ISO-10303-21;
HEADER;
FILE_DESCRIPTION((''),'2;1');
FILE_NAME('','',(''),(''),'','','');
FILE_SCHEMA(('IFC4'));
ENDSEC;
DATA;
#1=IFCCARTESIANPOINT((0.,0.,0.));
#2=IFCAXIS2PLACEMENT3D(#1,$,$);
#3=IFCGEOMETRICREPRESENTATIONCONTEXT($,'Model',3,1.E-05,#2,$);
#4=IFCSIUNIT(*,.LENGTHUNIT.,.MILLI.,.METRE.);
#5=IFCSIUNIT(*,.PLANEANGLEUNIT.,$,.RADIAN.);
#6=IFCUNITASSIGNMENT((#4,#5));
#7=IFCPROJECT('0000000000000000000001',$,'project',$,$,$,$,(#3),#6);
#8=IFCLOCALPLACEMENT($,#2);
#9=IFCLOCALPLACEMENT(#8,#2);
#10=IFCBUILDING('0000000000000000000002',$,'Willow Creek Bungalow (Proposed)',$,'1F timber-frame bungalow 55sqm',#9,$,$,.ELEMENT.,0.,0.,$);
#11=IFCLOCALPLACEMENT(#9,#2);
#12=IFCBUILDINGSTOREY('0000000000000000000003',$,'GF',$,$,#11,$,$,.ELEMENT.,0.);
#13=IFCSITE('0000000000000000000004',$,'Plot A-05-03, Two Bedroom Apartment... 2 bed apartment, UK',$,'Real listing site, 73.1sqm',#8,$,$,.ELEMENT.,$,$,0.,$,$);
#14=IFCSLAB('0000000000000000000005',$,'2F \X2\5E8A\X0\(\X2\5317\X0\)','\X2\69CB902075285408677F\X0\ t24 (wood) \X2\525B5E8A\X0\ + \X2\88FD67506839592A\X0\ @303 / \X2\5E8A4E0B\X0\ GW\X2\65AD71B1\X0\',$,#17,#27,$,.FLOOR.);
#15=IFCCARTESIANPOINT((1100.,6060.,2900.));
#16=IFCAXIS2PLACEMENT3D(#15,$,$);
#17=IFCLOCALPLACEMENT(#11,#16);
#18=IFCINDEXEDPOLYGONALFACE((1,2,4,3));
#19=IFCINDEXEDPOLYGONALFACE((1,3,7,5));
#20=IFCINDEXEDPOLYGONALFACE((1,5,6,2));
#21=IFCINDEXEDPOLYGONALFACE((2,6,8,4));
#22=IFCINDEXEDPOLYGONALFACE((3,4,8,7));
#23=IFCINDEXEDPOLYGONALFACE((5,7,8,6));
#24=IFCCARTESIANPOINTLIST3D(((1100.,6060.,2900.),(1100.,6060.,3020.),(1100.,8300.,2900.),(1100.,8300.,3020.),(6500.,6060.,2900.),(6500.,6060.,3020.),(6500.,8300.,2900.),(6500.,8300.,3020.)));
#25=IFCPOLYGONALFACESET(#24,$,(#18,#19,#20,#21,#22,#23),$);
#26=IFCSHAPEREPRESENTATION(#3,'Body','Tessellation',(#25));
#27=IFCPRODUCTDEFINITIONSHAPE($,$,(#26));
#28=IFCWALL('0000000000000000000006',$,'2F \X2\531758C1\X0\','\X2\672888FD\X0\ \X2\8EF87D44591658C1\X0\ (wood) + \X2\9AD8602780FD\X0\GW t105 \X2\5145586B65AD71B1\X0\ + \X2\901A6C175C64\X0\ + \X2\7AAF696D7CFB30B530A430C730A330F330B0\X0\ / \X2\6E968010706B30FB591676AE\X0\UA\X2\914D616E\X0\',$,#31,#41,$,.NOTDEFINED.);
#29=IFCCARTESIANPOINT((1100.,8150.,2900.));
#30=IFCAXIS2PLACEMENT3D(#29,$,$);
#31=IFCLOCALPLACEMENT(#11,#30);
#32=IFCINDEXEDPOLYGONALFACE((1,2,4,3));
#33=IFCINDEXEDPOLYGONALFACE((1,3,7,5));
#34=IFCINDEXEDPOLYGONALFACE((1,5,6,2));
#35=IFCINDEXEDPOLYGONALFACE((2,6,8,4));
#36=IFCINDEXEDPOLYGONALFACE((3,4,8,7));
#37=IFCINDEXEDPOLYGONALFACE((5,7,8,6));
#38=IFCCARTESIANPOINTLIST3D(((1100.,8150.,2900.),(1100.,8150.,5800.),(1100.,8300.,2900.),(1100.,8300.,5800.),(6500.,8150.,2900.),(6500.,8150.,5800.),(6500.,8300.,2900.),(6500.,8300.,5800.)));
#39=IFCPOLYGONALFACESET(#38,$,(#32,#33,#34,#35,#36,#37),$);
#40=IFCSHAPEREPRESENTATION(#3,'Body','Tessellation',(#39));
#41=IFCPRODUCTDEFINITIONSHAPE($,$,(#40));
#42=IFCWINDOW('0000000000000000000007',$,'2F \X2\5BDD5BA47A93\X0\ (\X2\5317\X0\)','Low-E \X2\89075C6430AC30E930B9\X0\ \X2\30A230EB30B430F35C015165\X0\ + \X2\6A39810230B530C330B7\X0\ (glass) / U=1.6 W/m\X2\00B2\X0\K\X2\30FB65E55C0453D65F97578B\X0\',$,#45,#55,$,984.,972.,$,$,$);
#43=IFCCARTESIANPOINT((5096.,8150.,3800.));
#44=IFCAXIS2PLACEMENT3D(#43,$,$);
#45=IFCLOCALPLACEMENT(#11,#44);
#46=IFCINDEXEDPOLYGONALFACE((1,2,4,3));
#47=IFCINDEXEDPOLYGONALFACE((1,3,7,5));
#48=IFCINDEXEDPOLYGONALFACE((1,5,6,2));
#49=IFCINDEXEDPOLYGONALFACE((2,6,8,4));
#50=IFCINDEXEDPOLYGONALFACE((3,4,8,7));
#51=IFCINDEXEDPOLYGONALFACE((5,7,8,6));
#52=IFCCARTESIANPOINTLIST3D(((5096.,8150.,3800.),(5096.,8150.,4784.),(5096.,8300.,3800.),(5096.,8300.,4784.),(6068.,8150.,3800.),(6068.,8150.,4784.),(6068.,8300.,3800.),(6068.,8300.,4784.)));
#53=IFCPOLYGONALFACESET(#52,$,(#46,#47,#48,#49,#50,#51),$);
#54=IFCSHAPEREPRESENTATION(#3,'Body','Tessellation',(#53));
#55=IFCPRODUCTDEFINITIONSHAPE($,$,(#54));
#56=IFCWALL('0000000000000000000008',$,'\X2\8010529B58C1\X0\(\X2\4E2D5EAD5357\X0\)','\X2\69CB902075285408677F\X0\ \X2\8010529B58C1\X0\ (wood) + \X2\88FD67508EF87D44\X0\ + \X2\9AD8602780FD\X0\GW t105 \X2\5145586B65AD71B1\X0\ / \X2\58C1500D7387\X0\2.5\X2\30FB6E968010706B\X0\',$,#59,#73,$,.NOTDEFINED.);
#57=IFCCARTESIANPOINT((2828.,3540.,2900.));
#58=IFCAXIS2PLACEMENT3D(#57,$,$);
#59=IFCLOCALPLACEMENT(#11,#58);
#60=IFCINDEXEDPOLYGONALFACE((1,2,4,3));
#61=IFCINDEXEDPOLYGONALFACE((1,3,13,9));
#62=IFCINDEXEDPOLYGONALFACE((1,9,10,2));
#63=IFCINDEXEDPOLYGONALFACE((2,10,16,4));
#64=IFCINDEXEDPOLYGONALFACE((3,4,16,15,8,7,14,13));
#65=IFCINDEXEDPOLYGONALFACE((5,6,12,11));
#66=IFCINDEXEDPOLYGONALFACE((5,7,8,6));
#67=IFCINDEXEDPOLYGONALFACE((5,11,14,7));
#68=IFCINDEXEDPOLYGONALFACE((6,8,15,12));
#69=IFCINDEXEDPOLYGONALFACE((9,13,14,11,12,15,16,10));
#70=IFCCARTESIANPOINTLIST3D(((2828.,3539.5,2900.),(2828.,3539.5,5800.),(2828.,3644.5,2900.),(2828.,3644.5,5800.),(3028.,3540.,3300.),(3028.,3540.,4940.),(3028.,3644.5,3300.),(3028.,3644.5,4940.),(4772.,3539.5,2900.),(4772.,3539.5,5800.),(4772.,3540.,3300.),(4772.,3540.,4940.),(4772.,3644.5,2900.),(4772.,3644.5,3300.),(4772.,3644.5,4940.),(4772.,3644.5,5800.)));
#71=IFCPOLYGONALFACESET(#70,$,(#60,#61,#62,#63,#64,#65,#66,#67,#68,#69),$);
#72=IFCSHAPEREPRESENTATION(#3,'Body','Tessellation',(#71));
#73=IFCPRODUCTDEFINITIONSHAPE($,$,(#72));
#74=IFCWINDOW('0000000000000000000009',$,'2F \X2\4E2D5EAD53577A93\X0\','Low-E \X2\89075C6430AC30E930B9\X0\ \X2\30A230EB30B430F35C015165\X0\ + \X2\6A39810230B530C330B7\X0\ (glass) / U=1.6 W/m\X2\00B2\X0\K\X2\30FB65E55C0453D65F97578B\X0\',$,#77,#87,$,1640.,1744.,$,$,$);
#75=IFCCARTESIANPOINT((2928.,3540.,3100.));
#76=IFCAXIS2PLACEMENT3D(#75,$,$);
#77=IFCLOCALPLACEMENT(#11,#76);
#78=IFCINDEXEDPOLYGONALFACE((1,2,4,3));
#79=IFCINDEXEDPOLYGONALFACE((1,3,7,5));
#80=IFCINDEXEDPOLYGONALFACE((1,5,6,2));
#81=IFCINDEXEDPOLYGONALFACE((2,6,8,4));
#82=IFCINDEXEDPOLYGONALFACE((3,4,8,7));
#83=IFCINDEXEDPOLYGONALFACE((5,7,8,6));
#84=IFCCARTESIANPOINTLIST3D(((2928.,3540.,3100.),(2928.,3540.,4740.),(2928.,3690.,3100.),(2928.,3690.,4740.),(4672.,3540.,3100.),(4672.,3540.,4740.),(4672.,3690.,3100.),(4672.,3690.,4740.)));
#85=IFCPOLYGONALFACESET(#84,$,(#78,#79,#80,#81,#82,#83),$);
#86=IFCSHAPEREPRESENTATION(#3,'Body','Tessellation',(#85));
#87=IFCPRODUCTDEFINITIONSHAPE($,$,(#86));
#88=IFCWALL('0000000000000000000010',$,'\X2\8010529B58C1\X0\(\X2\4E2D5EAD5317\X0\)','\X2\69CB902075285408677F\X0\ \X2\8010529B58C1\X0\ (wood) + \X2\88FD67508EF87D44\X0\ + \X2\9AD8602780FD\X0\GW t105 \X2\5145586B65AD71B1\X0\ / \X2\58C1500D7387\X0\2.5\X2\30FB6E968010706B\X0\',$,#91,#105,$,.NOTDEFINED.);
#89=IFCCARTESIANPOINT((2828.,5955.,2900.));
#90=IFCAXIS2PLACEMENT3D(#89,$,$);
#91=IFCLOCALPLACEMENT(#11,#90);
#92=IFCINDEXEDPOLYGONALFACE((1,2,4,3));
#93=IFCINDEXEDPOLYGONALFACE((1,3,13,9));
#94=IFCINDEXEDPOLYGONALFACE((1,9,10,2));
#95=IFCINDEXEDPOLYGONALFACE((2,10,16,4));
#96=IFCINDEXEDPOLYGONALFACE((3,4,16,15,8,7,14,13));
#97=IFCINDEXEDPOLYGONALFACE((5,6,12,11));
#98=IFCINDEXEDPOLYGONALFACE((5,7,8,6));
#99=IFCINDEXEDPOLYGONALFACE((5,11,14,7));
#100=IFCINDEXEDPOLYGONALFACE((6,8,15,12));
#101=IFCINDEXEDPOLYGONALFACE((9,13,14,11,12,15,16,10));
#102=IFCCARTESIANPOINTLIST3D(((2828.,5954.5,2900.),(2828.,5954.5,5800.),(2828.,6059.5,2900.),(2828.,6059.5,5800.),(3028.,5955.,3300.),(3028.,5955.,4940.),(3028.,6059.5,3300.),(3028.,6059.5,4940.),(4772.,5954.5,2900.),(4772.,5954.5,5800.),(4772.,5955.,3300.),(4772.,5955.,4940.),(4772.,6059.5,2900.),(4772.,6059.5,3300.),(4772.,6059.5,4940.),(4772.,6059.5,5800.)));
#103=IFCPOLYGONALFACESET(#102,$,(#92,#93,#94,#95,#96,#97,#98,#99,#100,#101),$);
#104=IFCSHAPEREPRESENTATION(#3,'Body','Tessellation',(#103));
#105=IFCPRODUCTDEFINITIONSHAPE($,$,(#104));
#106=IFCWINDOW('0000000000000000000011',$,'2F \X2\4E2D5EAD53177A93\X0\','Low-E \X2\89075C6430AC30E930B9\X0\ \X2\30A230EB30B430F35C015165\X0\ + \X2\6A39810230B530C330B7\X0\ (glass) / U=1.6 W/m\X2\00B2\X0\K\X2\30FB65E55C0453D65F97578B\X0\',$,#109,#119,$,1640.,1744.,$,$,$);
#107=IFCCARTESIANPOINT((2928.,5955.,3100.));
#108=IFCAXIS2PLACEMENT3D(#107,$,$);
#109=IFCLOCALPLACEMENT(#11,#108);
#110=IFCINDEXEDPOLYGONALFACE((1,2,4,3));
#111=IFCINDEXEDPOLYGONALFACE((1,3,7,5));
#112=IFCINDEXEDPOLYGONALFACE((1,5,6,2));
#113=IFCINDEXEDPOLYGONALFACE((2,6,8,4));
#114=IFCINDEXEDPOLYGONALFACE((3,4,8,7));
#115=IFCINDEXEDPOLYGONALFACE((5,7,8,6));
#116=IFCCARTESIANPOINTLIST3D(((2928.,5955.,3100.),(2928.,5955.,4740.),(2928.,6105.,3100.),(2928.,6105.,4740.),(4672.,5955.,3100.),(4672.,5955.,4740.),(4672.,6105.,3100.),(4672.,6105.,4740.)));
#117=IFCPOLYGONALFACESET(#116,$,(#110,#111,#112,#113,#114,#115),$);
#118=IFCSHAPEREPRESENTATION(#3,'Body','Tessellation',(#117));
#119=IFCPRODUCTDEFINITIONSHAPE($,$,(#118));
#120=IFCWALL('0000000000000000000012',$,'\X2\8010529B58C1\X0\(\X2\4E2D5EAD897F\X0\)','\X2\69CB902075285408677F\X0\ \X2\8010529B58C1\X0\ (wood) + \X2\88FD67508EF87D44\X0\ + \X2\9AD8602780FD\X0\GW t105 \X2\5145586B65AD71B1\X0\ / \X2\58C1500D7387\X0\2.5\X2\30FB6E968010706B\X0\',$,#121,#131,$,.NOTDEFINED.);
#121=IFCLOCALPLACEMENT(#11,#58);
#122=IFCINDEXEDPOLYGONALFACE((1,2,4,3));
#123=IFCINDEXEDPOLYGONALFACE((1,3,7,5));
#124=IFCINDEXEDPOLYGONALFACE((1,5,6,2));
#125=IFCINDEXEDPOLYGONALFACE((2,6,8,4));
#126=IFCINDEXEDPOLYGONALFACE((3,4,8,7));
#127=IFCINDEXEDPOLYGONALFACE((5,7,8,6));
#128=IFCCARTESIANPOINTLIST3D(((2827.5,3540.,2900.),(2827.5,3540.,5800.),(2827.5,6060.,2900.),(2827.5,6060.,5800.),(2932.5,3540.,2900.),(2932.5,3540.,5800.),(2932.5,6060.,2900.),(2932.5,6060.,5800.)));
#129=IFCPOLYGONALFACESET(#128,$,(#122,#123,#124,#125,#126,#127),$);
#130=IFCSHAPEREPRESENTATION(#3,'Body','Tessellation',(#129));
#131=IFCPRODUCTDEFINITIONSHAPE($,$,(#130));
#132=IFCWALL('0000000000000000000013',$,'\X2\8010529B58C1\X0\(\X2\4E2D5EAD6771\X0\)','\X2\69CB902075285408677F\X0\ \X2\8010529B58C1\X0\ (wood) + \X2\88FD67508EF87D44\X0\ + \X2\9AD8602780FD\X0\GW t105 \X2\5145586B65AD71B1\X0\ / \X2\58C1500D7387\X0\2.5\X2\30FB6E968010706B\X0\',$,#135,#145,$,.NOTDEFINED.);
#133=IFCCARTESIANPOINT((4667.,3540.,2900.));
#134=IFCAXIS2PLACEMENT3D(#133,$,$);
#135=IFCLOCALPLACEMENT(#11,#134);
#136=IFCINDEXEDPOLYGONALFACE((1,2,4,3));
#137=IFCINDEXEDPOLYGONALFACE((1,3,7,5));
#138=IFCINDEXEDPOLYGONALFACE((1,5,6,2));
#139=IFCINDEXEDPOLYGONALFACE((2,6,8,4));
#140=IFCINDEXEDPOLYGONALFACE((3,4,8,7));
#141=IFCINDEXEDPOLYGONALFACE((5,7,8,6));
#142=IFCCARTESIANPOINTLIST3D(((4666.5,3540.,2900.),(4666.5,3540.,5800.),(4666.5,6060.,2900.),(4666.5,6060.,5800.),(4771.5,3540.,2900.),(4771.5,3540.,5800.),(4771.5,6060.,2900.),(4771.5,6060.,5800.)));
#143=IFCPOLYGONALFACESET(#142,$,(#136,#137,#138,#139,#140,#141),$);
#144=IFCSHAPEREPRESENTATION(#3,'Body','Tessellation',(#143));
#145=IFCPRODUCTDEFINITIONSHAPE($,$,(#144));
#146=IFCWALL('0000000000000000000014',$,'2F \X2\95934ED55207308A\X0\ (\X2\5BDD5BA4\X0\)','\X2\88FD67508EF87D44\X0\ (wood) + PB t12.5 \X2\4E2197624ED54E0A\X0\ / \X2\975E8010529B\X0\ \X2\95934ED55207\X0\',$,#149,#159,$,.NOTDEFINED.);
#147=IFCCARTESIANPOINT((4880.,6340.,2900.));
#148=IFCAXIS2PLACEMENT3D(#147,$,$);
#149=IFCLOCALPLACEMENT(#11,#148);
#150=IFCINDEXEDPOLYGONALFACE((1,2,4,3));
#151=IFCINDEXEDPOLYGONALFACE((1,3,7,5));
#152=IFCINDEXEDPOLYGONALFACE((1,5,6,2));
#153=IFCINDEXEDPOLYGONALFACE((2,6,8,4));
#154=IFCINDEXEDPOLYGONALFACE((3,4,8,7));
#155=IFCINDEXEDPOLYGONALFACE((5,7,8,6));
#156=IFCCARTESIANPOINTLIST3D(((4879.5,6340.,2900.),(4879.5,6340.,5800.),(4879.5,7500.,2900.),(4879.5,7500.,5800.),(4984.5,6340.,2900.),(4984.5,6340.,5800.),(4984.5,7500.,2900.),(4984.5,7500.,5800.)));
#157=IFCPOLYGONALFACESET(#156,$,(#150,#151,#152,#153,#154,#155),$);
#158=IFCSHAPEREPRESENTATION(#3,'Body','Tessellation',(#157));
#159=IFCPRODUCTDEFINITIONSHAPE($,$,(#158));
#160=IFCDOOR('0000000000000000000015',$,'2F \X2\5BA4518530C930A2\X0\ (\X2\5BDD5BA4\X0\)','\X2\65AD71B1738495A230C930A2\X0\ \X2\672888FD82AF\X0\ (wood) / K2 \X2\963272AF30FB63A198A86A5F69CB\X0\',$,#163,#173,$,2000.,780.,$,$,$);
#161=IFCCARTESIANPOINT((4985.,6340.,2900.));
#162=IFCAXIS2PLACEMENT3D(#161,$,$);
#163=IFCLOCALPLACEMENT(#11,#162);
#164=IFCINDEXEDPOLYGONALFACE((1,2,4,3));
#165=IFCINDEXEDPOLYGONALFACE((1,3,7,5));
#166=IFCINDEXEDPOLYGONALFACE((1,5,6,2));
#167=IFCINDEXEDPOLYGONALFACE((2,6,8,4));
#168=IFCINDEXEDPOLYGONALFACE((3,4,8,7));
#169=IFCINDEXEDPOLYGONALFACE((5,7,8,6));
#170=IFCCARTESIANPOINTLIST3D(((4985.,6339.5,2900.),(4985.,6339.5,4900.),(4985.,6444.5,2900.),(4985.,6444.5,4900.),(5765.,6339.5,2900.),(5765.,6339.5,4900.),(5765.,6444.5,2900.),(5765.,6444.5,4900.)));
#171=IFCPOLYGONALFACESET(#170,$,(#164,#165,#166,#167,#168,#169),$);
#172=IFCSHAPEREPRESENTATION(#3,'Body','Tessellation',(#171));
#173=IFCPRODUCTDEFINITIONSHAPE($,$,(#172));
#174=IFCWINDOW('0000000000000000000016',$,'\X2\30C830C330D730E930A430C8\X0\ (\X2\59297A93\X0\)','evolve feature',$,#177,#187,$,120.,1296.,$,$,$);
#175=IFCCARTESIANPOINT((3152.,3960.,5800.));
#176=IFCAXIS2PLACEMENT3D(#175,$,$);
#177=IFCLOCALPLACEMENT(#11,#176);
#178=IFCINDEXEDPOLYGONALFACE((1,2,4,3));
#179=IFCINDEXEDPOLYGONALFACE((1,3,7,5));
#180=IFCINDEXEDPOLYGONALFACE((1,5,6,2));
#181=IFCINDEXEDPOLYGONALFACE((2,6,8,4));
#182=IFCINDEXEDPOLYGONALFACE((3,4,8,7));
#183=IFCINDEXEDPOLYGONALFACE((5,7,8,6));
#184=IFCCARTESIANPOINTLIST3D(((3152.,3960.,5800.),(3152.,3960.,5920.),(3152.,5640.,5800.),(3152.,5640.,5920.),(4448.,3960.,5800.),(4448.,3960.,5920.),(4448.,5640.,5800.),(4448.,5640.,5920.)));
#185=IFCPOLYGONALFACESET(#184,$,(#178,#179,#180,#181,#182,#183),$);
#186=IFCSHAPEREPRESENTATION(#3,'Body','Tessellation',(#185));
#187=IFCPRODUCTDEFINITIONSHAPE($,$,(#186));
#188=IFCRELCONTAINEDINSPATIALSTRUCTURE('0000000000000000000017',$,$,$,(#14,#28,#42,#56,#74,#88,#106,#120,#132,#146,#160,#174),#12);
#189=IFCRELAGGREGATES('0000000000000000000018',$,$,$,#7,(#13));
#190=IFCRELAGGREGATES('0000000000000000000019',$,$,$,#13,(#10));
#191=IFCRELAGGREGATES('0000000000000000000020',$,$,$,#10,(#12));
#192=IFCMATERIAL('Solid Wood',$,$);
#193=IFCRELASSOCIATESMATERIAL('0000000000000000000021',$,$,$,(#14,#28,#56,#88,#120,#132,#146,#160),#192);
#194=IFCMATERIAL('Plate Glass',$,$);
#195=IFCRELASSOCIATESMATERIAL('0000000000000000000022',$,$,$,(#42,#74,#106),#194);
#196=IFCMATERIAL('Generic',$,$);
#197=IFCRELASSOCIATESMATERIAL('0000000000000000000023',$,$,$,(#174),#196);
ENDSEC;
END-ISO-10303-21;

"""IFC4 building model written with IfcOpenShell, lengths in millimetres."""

from ifc_helpers import new_model, si_unit, frame, frame_2d, origin, place, context, project, spatial, rectangle, extrude, material, element, fill, save


model = new_model("IFC4")

# Units and contexts
model_context = context("Model", 3, precision=1e-05, world=origin())
ifc_project = project(units=[si_unit("LENGTHUNIT", "METRE", prefix="MILLI"), si_unit("PLANEANGLEUNIT", "RADIAN")], contexts=[model_context])

# Site, building, storey
site_placement = place(None, origin())
site = spatial("IfcSite", under=ifc_project, at=site_placement, Name="Plot A-05-03, Two Bedroom Apartment... 2 bed apartment, UK", ObjectType="Real listing site, 73.1sqm", CompositionType="ELEMENT", RefElevation=0.0)
building_placement = place(site_placement, origin())
building = spatial("IfcBuilding", under=site, at=building_placement, Name="Willow Creek Bungalow (Proposed)", ObjectType="1F timber-frame bungalow 55sqm", CompositionType="ELEMENT", ElevationOfRefHeight=0.0, ElevationOfTerrain=0.0)
storey_placement = place(building_placement, origin())
storey = spatial("IfcBuildingStorey", under=building, at=storey_placement, Name="GF", CompositionType="ELEMENT", Elevation=0.0)

# Slab
ifc_material_1 = material(Name="Solid Wood")
slab_placement = place(storey_placement, frame((1100.0, 6060.0, 2900.0)))
element("IfcSlab", 1, at=slab_placement, inside=storey, material=ifc_material_1, Name="2F 床(北)", Description="構造用合板 t24 (wood) 剛床 + 製材根太 @303 / 床下 GW断熱", PredefinedType="FLOOR", context=model_context, shape_type="SweptSolid", body=[
    extrude(rectangle(XDim=5400.0, YDim=2240.0, at=frame_2d((2700.0, 1120.0))), frame((1100.0, 6060.0, 2900.0)), (0.0, 0.0, 1.0), 120.0),
])

# Walls, openings, windows
wall_1_placement = place(storey_placement, frame((1100.0, 8150.0, 2900.0)))
wall_1 = element("IfcWall", 2, at=wall_1_placement, inside=storey, material=ifc_material_1, Name="2F 北壁", Description="木製 軸組外壁 (wood) + 高性能GW t105 充填断熱 + 通気層 + 窯業系サイディング / 準耐火・外皮UA配慮", PredefinedType="NOTDEFINED", context=model_context, shape_type="SweptSolid", body=[
    extrude(rectangle(XDim=5400.0, YDim=150.0, at=frame_2d((2700.0, 75.0))), frame((1100.0, 8150.0, 2900.0)), (0.0, 0.0, 1.0), 2900.0),
])
opening_1_placement = place(storey_placement, frame((5096.0, 8150.0, 3800.0)))
opening_1 = element("IfcOpeningElement", 3, at=opening_1_placement, cuts=wall_1, PredefinedType="NOTDEFINED", context=model_context, shape_type="SweptSolid", body=[
    extrude(rectangle(XDim=972.0, YDim=150.0, at=frame_2d((486.0, 75.0))), frame((5096.0, 8150.0, 3800.0)), (0.0, 0.0, 1.0), 984.0),
])
ifc_material_2 = material(Name="Plate Glass")
window_1_placement = place(storey_placement, frame((5096.0, 8150.0, 3800.0)))
window_1 = element("IfcWindow", 4, at=window_1_placement, inside=storey, material=ifc_material_2, Name="2F 寝室窓 (北)", Description="Low-E 複層ガラス アルゴン封入 + 樹脂サッシ (glass) / U=1.6 W/m²K・日射取得型", OverallHeight=984.0, OverallWidth=972.0, context=model_context, shape_type="SweptSolid", body=[
    extrude(rectangle(XDim=972.0, YDim=150.0, at=frame_2d((486.0, 75.0))), frame((5096.0, 8150.0, 3800.0)), (0.0, 0.0, 1.0), 984.0),
])
fill(opening_1, window_1)
wall_2_placement = place(storey_placement, frame((2828.0, 3540.0, 2900.0)))
wall_2 = element("IfcWall", 5, at=wall_2_placement, inside=storey, material=ifc_material_1, Name="耐力壁(中庭南)", Description="構造用合板 耐力壁 (wood) + 製材軸組 + 高性能GW t105 充填断熱 / 壁倍率2.5・準耐火", PredefinedType="NOTDEFINED", context=model_context, shape_type="SweptSolid", body=[
    extrude(rectangle(XDim=1944.0, YDim=105.0, at=frame_2d((972.0, 52.0))), frame((2828.0, 3540.0, 2900.0)), (0.0, 0.0, 1.0), 2900.0),
])
opening_2_placement = place(storey_placement, frame((2928.0, 3540.0, 3100.0)))
opening_2 = element("IfcOpeningElement", 6, at=opening_2_placement, cuts=wall_2, PredefinedType="NOTDEFINED", context=model_context, shape_type="SweptSolid", body=[
    extrude(rectangle(XDim=1744.0, YDim=150.0, at=frame_2d((872.0, 75.0))), frame((2928.0, 3540.0, 3100.0)), (0.0, 0.0, 1.0), 1640.0),
])
window_2_placement = place(storey_placement, frame((2928.0, 3540.0, 3100.0)))
window_2 = element("IfcWindow", 7, at=window_2_placement, inside=storey, material=ifc_material_2, Name="2F 中庭南窓", Description="Low-E 複層ガラス アルゴン封入 + 樹脂サッシ (glass) / U=1.6 W/m²K・日射取得型", OverallHeight=1640.0, OverallWidth=1744.0, context=model_context, shape_type="SweptSolid", body=[
    extrude(rectangle(XDim=1744.0, YDim=150.0, at=frame_2d((872.0, 75.0))), frame((2928.0, 3540.0, 3100.0)), (0.0, 0.0, 1.0), 1640.0),
])
fill(opening_2, window_2)
wall_3_placement = place(storey_placement, frame((2828.0, 5955.0, 2900.0)))
wall_3 = element("IfcWall", 8, at=wall_3_placement, inside=storey, material=ifc_material_1, Name="耐力壁(中庭北)", Description="構造用合板 耐力壁 (wood) + 製材軸組 + 高性能GW t105 充填断熱 / 壁倍率2.5・準耐火", PredefinedType="NOTDEFINED", context=model_context, shape_type="SweptSolid", body=[
    extrude(rectangle(XDim=1944.0, YDim=105.0, at=frame_2d((972.0, 52.0))), frame((2828.0, 5955.0, 2900.0)), (0.0, 0.0, 1.0), 2900.0),
])
opening_3_placement = place(storey_placement, frame((2928.0, 5955.0, 3100.0)))
opening_3 = element("IfcOpeningElement", 9, at=opening_3_placement, cuts=wall_3, PredefinedType="NOTDEFINED", context=model_context, shape_type="SweptSolid", body=[
    extrude(rectangle(XDim=1744.0, YDim=150.0, at=frame_2d((872.0, 75.0))), frame((2928.0, 5955.0, 3100.0)), (0.0, 0.0, 1.0), 1640.0),
])
window_3_placement = place(storey_placement, frame((2928.0, 5955.0, 3100.0)))
window_3 = element("IfcWindow", 10, at=window_3_placement, inside=storey, material=ifc_material_2, Name="2F 中庭北窓", Description="Low-E 複層ガラス アルゴン封入 + 樹脂サッシ (glass) / U=1.6 W/m²K・日射取得型", OverallHeight=1640.0, OverallWidth=1744.0, context=model_context, shape_type="SweptSolid", body=[
    extrude(rectangle(XDim=1744.0, YDim=150.0, at=frame_2d((872.0, 75.0))), frame((2928.0, 5955.0, 3100.0)), (0.0, 0.0, 1.0), 1640.0),
])
fill(opening_3, window_3)

# Walls
wall_4_placement = place(storey_placement, frame((2828.0, 3540.0, 2900.0)))
element("IfcWall", 11, at=wall_4_placement, inside=storey, material=ifc_material_1, Name="耐力壁(中庭西)", Description="構造用合板 耐力壁 (wood) + 製材軸組 + 高性能GW t105 充填断熱 / 壁倍率2.5・準耐火", PredefinedType="NOTDEFINED", context=model_context, shape_type="SweptSolid", body=[
    extrude(rectangle(XDim=105.0, YDim=2520.0, at=frame_2d((52.0, 1260.0))), frame((2828.0, 3540.0, 2900.0)), (0.0, 0.0, 1.0), 2900.0),
])
wall_5_placement = place(storey_placement, frame((4667.0, 3540.0, 2900.0)))
element("IfcWall", 12, at=wall_5_placement, inside=storey, material=ifc_material_1, Name="耐力壁(中庭東)", Description="構造用合板 耐力壁 (wood) + 製材軸組 + 高性能GW t105 充填断熱 / 壁倍率2.5・準耐火", PredefinedType="NOTDEFINED", context=model_context, shape_type="SweptSolid", body=[
    extrude(rectangle(XDim=105.0, YDim=2520.0, at=frame_2d((52.0, 1260.0))), frame((4667.0, 3540.0, 2900.0)), (0.0, 0.0, 1.0), 2900.0),
])
wall_6_placement = place(storey_placement, frame((4880.0, 6340.0, 2900.0)))
element("IfcWall", 13, at=wall_6_placement, inside=storey, material=ifc_material_1, Name="2F 間仕切り (寝室)", Description="製材軸組 (wood) + PB t12.5 両面仕上 / 非耐力 間仕切", PredefinedType="NOTDEFINED", context=model_context, shape_type="SweptSolid", body=[
    extrude(rectangle(XDim=105.0, YDim=1160.0, at=frame_2d((52.0, 580.0))), frame((4880.0, 6340.0, 2900.0)), (0.0, 0.0, 1.0), 2900.0),
])

# Door
door_placement = place(storey_placement, frame((4985.0, 6340.0, 2900.0)))
element("IfcDoor", 14, at=door_placement, inside=storey, material=ifc_material_1, Name="2F 室内ドア (寝室)", Description="断熱玄関ドア 木製芯 (wood) / K2 防犯・採風機構", OverallHeight=2000.0, OverallWidth=780.0, context=model_context, shape_type="SweptSolid", body=[
    extrude(rectangle(XDim=780.0, YDim=105.0, at=frame_2d((390.0, 52.0))), frame((4985.0, 6340.0, 2900.0)), (0.0, 0.0, 1.0), 2000.0),
])

# Window
ifc_material_3 = material(Name="Generic")
window_4_placement = place(storey_placement, frame((3152.0, 3960.0, 5800.0)))
element("IfcWindow", 15, at=window_4_placement, inside=storey, material=ifc_material_3, Name="トップライト (天窓)", Description="evolve feature", OverallHeight=120.0, OverallWidth=1296.0, context=model_context, shape_type="SweptSolid", body=[
    extrude(rectangle(XDim=1296.0, YDim=1680.0, at=frame_2d((648.0, 840.0))), frame((3152.0, 3960.0, 5800.0)), (0.0, 0.0, 1.0), 120.0),
])

save(model, "model.ifc")
